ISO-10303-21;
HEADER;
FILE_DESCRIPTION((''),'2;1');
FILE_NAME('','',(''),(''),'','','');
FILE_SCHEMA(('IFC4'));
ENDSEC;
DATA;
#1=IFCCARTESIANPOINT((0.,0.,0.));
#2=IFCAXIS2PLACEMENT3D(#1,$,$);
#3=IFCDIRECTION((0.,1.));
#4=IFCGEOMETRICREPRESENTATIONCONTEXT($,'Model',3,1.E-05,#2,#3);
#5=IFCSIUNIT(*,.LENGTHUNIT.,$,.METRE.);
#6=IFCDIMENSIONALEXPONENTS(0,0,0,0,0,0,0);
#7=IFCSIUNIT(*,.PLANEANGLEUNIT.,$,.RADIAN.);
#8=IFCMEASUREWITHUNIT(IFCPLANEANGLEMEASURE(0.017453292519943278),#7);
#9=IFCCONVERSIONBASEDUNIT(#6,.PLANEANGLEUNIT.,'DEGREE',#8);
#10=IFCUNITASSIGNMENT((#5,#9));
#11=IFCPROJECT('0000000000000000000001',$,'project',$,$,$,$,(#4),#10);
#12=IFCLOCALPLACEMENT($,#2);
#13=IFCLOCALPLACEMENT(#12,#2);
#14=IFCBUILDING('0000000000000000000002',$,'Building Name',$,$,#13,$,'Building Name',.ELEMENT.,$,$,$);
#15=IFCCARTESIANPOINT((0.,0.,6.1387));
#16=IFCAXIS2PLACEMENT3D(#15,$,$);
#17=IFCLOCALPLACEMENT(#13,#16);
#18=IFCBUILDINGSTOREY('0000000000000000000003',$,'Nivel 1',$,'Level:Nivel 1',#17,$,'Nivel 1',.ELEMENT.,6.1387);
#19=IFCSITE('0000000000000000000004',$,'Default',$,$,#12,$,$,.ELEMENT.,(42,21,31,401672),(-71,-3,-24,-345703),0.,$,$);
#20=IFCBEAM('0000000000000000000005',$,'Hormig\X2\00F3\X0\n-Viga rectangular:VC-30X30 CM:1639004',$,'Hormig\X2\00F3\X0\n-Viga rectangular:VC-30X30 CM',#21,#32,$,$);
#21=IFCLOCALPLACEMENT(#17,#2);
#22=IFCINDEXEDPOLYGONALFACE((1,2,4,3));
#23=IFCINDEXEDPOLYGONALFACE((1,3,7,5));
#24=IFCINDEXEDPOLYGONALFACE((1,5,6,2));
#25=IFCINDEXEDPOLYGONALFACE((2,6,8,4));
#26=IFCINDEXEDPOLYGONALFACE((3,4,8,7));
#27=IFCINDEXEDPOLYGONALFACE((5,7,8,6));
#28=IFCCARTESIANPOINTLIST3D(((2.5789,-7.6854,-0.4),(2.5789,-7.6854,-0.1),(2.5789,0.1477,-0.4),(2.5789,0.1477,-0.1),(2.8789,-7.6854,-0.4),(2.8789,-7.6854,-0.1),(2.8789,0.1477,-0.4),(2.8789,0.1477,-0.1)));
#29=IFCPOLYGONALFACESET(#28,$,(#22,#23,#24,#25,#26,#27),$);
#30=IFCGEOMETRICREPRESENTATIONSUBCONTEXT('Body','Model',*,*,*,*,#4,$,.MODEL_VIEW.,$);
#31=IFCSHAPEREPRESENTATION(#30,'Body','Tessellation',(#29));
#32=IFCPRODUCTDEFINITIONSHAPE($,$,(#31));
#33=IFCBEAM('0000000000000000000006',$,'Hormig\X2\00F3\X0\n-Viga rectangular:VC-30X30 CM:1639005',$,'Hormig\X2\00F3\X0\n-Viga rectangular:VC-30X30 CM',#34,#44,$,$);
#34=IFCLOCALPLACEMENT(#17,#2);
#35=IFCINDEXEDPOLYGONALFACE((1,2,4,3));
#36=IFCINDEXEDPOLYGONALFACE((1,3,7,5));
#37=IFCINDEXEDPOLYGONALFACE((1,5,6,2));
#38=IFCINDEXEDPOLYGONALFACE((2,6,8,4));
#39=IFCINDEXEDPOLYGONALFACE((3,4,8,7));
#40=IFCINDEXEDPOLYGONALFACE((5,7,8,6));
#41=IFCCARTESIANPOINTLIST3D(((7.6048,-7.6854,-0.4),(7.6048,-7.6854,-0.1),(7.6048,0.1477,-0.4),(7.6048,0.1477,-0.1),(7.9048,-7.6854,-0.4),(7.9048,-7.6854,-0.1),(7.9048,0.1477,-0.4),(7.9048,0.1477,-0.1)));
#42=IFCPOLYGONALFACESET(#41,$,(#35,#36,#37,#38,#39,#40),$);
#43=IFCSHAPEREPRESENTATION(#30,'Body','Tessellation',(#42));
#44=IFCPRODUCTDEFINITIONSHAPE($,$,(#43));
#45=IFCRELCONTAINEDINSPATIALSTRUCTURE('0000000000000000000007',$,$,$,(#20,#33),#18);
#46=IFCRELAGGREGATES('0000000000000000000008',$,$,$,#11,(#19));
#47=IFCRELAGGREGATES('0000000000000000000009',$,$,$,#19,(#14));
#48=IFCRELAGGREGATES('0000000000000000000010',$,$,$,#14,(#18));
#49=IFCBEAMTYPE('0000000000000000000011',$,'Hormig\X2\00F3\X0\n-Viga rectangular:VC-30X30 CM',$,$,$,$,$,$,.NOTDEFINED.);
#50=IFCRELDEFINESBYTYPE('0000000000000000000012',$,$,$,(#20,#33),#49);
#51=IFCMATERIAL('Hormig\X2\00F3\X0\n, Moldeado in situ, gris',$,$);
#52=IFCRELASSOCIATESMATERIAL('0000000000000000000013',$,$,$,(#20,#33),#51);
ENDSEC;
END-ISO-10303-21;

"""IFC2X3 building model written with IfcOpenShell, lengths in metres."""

from ifc_helpers import new_model, entity, si_unit, converted_unit, direction, frame, frame_2d, origin, place, context, subcontext, project, spatial, rectangle, extrude, material, type_object, element, save


model = new_model("IFC2X3")

# Units and contexts
model_context = context("Model", 3, precision=1e-05, world=origin(), true_north=direction((0.0, 1.0)))
body_context = subcontext(model_context, "Body", "Model", "MODEL_VIEW")
ifc_project = project(units=[si_unit("LENGTHUNIT", "METRE"), converted_unit("PLANEANGLEUNIT", "DEGREE", entity("IfcPlaneAngleMeasure", 0.017453292519943278), si_unit("PLANEANGLEUNIT", "RADIAN"), dimensions=[0, 0, 0, 0, 0, 0, 0])], contexts=[model_context])

# Site, building, storey
site_placement = place(None, origin())
site = spatial("IfcSite", under=ifc_project, at=site_placement, Name="Default", CompositionType="ELEMENT", RefLatitude=(42, 21, 31, 401672), RefLongitude=(-71, -3, -24, -345703), RefElevation=0.0)
building_placement = place(site_placement, origin())
building = spatial("IfcBuilding", under=site, at=building_placement, Name="Building Name", LongName="Building Name", CompositionType="ELEMENT")
storey_placement = place(building_placement, frame((0.0, 0.0, 6.1387)))
storey = spatial("IfcBuildingStorey", under=building, at=storey_placement, Name="Nivel 1", ObjectType="Level:Nivel 1", LongName="Nivel 1", CompositionType="ELEMENT", Elevation=6.1387)

# Beams
ifc_material = material(Name="Hormigón, Moldeado in situ, gris")
beam_type = type_object("IfcBeamType", Name="Hormigón-Viga rectangular:VC-30X30 CM", PredefinedType="NOTDEFINED")
beam_1_placement = place(storey_placement, frame((2.7289, 0.2977, -0.1), z_axis=(0.0, 0.0, 1.0), x_axis=(0.0, -1.0, 0.0)))
element("IfcBeam", 1, at=beam_1_placement, inside=storey, type_object=beam_type, material=ifc_material, Name="Hormigón-Viga rectangular:VC-30X30 CM:1639004", ObjectType="Hormigón-Viga rectangular:VC-30X30 CM", context=body_context, shape_type="SweptSolid", body=[
    extrude(rectangle(XDim=0.3, YDim=0.3, at=frame_2d((0.0, 0.0), x_axis=(1.0, 0.0))), frame((0.15, 0.0, -0.15), z_axis=(1.0, 0.0, 0.0), x_axis=(0.0, 0.0, -1.0)), (0.0, 0.0, 1.0), 7.8332),
])
beam_2_placement = place(storey_placement, frame((7.7548, 0.2977, -0.1), z_axis=(0.0, 0.0, 1.0), x_axis=(0.0, -1.0, 0.0)))
element("IfcBeam", 2, at=beam_2_placement, inside=storey, type_object=beam_type, material=ifc_material, Name="Hormigón-Viga rectangular:VC-30X30 CM:1639005", ObjectType="Hormigón-Viga rectangular:VC-30X30 CM", context=body_context, shape_type="SweptSolid", body=[
    extrude(rectangle(XDim=0.3, YDim=0.3, at=frame_2d((0.0, 0.0), x_axis=(1.0, 0.0))), frame((0.15, 0.0, -0.15), z_axis=(1.0, 0.0, 0.0), x_axis=(0.0, 0.0, -1.0)), (0.0, 0.0, 1.0), 7.8332),
])

save(model, "model.ifc")
